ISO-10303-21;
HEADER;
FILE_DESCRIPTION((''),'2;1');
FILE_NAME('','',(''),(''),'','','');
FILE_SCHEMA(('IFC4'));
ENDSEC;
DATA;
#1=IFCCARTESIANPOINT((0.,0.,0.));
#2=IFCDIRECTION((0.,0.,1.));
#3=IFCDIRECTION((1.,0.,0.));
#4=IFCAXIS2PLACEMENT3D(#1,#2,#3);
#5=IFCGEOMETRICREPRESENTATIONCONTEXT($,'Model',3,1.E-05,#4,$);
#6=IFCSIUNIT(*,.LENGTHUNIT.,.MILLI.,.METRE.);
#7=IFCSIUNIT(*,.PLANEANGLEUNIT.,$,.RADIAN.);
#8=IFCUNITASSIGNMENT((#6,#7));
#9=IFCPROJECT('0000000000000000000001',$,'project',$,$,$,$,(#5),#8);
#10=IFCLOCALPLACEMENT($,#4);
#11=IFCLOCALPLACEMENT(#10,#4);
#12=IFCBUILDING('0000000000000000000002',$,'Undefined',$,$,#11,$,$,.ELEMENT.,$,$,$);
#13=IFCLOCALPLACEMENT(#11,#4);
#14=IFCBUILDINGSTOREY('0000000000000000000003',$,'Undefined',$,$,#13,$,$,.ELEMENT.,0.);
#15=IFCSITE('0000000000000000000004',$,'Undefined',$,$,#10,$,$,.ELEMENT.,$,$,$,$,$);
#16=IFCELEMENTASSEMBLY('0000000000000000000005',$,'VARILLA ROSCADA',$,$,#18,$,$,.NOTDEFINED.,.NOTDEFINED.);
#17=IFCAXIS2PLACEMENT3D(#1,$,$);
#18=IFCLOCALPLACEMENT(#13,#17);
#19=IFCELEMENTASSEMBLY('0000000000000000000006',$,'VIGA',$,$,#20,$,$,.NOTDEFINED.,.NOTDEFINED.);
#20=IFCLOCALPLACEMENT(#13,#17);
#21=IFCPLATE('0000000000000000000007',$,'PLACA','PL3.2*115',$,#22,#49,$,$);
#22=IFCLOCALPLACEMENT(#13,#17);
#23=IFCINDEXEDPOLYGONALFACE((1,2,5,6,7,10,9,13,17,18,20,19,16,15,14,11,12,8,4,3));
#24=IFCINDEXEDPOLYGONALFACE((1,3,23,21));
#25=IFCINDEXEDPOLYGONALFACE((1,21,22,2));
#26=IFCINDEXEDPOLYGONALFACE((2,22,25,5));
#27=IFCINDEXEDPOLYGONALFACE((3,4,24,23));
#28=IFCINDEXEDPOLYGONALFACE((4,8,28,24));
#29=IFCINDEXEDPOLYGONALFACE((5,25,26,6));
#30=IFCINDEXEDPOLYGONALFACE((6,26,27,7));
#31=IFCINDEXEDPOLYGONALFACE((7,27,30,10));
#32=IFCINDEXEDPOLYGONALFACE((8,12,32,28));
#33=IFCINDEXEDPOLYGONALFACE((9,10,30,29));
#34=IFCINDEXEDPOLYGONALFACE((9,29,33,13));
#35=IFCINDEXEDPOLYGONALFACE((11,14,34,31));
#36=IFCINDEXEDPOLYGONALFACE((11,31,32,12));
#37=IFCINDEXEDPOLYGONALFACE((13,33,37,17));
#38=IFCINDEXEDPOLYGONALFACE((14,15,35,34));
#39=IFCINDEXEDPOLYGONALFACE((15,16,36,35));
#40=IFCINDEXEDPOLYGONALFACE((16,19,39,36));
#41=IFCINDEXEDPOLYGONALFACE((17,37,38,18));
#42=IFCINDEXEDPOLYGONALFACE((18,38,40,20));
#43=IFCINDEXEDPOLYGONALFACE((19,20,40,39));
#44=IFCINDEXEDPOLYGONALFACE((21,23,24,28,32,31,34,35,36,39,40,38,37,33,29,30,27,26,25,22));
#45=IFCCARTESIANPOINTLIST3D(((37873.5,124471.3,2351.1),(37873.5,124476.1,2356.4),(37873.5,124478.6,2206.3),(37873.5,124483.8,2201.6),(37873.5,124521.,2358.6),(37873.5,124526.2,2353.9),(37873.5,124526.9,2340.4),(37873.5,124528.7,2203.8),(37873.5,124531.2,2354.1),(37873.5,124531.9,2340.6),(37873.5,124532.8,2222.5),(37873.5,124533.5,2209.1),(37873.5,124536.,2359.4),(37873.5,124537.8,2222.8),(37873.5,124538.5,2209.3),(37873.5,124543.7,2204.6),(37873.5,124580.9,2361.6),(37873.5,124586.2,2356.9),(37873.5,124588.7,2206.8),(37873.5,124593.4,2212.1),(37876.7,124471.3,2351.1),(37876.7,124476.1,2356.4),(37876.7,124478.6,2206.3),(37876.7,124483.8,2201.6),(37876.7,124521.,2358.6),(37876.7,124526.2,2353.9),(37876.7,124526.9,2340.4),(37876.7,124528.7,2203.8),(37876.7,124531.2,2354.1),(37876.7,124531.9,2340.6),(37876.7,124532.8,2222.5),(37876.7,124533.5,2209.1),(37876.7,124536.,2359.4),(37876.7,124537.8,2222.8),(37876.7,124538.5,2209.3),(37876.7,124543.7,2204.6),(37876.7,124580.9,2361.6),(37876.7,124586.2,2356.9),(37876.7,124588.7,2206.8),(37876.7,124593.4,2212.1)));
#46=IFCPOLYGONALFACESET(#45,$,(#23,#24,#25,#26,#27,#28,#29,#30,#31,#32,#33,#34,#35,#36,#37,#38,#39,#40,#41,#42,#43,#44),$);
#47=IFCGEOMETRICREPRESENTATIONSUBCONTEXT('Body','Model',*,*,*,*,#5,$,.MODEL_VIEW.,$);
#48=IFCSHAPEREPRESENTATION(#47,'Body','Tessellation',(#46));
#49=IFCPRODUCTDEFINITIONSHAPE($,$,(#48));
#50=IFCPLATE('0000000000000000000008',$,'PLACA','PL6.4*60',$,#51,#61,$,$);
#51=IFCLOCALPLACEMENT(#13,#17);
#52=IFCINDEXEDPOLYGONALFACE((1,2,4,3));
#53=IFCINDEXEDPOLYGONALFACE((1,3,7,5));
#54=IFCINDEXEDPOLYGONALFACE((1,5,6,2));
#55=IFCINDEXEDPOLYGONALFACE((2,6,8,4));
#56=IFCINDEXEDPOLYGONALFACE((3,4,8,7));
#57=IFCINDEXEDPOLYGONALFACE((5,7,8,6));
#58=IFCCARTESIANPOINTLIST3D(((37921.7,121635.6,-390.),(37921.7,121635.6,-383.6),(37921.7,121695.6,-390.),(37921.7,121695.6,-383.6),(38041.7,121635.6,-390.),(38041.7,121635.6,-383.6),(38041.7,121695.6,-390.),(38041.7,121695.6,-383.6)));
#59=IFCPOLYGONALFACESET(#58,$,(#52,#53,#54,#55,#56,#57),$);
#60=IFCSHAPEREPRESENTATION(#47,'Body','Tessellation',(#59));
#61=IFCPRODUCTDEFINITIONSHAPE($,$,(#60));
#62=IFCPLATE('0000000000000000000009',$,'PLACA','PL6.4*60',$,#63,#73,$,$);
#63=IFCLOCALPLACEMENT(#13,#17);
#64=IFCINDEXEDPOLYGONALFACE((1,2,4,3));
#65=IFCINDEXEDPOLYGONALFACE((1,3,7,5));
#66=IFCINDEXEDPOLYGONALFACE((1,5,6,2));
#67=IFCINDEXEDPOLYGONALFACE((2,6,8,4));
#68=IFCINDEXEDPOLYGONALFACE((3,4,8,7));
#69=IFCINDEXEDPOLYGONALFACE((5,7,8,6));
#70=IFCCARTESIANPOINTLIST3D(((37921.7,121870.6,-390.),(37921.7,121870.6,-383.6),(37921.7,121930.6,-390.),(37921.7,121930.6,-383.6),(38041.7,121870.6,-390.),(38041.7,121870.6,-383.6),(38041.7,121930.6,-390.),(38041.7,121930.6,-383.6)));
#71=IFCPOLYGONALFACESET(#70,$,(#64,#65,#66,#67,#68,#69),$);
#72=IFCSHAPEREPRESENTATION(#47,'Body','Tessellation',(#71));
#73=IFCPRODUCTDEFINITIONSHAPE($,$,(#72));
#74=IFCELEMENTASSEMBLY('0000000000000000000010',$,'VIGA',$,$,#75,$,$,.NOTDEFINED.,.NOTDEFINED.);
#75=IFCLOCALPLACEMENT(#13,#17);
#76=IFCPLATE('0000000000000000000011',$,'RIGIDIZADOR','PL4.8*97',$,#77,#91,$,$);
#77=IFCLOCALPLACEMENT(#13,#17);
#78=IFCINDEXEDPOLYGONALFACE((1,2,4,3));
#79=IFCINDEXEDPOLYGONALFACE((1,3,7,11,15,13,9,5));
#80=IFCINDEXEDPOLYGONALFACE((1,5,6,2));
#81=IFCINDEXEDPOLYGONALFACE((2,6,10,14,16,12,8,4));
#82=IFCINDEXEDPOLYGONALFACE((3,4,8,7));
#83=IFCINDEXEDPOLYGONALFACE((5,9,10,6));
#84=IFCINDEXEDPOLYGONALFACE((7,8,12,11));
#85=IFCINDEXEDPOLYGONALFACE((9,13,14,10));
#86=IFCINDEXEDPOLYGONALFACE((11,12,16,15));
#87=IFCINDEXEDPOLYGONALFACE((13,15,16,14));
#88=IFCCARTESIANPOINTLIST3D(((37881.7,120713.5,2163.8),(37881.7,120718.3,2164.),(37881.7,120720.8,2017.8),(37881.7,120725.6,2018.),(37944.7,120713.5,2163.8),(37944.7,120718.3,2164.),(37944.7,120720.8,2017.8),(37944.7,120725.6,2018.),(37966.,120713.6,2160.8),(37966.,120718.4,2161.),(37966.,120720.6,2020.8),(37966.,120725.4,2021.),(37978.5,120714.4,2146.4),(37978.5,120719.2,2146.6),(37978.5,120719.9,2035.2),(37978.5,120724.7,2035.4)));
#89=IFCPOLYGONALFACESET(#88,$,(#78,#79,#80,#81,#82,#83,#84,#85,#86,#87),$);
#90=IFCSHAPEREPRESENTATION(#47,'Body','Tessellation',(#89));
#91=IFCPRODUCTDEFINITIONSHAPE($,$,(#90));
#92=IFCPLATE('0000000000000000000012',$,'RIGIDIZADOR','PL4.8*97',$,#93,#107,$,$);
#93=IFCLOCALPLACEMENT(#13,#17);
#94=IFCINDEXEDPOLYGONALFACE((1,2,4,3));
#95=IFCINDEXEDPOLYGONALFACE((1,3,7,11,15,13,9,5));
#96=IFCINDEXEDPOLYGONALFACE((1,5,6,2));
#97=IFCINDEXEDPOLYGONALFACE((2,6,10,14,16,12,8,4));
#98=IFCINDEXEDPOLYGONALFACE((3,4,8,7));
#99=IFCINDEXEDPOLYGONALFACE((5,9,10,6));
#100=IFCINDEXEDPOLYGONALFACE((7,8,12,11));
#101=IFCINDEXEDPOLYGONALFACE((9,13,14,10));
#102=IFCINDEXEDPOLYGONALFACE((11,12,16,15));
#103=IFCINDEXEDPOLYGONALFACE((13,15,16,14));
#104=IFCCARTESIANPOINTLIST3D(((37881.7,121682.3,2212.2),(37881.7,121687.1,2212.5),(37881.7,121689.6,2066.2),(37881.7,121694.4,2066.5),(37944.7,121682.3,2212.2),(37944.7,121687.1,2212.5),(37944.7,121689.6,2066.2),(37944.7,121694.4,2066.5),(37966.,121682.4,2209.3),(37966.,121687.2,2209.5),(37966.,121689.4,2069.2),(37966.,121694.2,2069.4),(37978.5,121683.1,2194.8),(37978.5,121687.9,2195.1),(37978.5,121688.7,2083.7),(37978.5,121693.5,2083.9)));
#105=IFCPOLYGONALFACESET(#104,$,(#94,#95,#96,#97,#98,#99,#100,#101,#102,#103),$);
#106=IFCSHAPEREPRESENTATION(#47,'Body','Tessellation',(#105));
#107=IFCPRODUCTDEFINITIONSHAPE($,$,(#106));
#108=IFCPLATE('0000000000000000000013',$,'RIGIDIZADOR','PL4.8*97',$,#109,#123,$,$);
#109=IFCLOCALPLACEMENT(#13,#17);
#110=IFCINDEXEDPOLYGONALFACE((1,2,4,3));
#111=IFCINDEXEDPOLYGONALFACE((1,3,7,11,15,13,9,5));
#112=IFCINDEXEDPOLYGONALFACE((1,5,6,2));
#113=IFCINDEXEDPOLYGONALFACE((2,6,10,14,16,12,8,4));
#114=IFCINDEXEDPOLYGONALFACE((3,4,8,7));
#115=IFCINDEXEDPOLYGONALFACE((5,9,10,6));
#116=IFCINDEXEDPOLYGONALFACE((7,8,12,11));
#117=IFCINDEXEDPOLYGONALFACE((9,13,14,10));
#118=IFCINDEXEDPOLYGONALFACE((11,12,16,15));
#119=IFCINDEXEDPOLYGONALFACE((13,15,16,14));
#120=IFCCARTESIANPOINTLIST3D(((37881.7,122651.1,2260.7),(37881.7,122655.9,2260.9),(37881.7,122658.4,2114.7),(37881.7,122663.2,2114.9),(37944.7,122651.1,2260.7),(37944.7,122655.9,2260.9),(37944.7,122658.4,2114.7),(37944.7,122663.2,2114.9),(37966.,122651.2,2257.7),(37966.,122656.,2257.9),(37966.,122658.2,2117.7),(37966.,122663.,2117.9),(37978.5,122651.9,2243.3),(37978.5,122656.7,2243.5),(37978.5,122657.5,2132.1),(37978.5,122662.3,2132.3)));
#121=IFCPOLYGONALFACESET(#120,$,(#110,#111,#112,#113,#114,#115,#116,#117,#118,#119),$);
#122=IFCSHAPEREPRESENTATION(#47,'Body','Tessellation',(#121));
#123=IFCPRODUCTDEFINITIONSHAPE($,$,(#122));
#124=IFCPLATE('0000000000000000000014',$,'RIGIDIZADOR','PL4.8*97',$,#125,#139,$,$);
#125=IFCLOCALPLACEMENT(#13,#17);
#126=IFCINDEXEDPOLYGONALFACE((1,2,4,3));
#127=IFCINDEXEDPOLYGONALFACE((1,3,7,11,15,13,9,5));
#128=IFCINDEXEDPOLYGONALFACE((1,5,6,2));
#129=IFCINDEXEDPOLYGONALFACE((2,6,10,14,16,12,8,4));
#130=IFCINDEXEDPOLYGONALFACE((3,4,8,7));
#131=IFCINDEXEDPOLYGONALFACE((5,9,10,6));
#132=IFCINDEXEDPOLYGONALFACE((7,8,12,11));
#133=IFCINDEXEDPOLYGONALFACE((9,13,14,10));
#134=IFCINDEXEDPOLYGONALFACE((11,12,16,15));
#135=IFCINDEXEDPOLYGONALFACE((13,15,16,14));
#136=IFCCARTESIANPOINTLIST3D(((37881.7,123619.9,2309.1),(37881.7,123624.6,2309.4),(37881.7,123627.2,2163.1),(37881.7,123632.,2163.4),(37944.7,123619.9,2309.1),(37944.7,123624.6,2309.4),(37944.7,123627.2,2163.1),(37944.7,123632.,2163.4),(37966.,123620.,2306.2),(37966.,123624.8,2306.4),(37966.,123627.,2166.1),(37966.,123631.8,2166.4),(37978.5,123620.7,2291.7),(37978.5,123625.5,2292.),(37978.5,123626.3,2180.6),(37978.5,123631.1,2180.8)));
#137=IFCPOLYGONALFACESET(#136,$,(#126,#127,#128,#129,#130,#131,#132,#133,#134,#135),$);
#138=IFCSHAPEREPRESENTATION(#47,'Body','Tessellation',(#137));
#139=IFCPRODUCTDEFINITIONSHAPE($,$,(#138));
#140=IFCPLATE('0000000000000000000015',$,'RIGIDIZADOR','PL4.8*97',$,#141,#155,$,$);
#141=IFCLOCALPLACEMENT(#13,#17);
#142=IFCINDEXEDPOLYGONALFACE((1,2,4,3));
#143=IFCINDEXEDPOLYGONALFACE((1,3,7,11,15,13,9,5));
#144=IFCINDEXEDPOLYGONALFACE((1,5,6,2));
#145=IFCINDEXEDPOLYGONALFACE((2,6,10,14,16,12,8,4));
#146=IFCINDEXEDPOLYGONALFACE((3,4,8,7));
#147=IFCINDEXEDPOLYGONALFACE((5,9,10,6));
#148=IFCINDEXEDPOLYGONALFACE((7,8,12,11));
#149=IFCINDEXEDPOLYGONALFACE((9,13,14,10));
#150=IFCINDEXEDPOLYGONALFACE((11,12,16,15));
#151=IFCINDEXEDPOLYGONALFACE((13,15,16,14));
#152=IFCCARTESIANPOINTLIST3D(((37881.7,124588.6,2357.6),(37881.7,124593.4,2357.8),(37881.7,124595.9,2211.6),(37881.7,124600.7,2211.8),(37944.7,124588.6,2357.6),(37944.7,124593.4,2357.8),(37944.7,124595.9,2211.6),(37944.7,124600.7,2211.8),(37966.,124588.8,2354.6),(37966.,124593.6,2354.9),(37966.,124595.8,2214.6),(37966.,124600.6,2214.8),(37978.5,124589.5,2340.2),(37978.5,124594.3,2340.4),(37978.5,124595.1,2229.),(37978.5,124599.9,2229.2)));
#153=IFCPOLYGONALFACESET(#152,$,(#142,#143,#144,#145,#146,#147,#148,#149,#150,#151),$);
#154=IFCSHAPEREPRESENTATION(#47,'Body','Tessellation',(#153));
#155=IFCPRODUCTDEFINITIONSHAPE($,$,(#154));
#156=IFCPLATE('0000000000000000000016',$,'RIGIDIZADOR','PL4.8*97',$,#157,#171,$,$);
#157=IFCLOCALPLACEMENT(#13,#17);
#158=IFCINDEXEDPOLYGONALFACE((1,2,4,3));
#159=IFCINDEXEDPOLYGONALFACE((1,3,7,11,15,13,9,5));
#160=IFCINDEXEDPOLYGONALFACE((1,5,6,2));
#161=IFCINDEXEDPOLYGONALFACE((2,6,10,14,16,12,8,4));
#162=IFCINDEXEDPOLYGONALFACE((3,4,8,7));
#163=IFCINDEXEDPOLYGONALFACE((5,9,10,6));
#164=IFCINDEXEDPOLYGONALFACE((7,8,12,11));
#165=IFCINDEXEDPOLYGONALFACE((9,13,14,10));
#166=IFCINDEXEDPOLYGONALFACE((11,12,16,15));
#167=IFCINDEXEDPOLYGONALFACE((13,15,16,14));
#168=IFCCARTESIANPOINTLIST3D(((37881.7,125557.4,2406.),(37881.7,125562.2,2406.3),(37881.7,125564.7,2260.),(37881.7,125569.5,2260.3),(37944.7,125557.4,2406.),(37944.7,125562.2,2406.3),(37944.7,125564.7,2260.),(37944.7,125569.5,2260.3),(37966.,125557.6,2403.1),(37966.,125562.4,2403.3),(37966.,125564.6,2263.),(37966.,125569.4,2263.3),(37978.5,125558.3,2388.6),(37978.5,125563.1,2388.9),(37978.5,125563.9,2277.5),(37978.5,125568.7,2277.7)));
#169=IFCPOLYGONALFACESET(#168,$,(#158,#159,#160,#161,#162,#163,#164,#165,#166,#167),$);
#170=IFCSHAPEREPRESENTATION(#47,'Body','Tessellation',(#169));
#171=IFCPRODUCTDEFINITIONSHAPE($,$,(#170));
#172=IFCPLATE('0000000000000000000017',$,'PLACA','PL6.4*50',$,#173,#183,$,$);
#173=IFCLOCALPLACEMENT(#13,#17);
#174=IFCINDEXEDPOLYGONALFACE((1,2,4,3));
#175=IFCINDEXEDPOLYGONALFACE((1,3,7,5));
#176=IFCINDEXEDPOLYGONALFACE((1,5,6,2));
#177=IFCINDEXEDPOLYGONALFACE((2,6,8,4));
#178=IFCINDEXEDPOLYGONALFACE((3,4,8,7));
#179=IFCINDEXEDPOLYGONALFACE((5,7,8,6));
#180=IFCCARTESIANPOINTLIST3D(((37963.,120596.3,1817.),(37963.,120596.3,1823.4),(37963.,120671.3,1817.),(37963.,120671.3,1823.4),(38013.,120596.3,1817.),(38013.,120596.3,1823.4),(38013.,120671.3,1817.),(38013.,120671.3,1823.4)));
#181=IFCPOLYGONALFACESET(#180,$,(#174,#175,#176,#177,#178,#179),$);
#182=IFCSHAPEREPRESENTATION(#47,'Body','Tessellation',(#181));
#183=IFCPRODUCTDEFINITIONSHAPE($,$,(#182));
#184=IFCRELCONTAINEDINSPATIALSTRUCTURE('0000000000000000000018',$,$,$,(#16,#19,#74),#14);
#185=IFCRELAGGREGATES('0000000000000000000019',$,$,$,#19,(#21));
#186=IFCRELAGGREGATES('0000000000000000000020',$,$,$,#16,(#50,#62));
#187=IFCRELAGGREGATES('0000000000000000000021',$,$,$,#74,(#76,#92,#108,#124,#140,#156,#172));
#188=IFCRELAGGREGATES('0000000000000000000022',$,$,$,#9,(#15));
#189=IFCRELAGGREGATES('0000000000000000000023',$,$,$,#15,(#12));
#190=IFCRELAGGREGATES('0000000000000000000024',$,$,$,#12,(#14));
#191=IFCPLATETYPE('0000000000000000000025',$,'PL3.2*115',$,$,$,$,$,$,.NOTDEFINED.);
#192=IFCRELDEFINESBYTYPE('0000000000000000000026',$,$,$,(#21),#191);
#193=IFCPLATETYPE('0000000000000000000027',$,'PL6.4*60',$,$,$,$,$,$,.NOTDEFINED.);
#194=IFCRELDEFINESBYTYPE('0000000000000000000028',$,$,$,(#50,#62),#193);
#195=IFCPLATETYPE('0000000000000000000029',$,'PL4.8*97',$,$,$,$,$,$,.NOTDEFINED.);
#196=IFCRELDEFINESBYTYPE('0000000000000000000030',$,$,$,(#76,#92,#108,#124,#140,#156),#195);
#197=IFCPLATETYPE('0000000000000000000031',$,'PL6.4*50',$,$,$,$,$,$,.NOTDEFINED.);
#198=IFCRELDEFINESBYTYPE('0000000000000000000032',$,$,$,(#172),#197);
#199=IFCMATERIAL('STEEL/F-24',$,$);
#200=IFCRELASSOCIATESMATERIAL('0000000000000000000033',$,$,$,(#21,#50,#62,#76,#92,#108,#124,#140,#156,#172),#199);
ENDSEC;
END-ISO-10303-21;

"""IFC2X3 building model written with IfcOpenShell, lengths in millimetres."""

from ifc_helpers import new_model, si_unit, frame, origin_with_axes, place, context, subcontext, project, spatial, polyline, outline, extrude, material, type_object, element, aggregate, save


model = new_model("IFC2X3")

# Units and contexts
model_context = context("Model", 3, precision=1e-05, world=origin_with_axes())
body_context = subcontext(model_context, "Body", "Model", "MODEL_VIEW")
ifc_project = project(units=[si_unit("LENGTHUNIT", "METRE", prefix="MILLI"), si_unit("PLANEANGLEUNIT", "RADIAN")], contexts=[model_context])

# Site, building, storey
site_placement = place(None, origin_with_axes())
site = spatial("IfcSite", under=ifc_project, at=site_placement, Name="Undefined", CompositionType="ELEMENT")
building_placement = place(site_placement, origin_with_axes())
building = spatial("IfcBuilding", under=site, at=building_placement, Name="Undefined", CompositionType="ELEMENT")
storey_placement = place(building_placement, origin_with_axes())
storey = spatial("IfcBuildingStorey", under=building, at=storey_placement, Name="Undefined", CompositionType="ELEMENT", Elevation=0.0)

# Element assembly
assembly_1_placement = place(storey_placement, origin_with_axes())
assembly_1 = element("IfcElementAssembly", 1, at=assembly_1_placement, inside=storey, Name="VARILLA ROSCADA", AssemblyPlace="NOTDEFINED", PredefinedType="NOTDEFINED")

# Shared definitions
ifc_material_1 = material(Name="STEEL/F-24")

# Shared definitions
plate_type_1 = type_object("IfcPlateType", Name="PL3.2*115", PredefinedType="NOTDEFINED")

# Element assembly, plate
assembly_2_placement = place(storey_placement, origin_with_axes())
assembly_2 = element("IfcElementAssembly", 2, at=assembly_2_placement, inside=storey, Name="VIGA", AssemblyPlace="NOTDEFINED", PredefinedType="NOTDEFINED")
plate_1_placement = place(assembly_2_placement, frame((37875.1, 124471.1, 2356.1), z_axis=(-1.0, 0.0, 0.0), x_axis=(0.0, 0.998752, 0.04995)))
plate_1 = element("IfcPlate", 3, at=plate_1_placement, type_object=plate_type_1, material=ifc_material_1, Name="PLACA", Description="PL3.2*115", context=body_context, shape_type="SweptSolid", body=[
    extrude(outline(polyline([(0.0, 5.0), (5.0, 0.0), (50.0, 0.0), (55.0, 5.0), (55.0, 18.5), (60.0, 18.5), (60.0, 5.0), (65.0, 0.0), (110.0, 0.0), (115.0, 5.0), (115.0, 150.0), (110.0, 155.0), (65.0, 155.0), (60.0, 150.0), (60.0, 136.5), (55.0, 136.5), (55.0, 150.0), (50.0, 155.0), (5.0, 155.0), (0.0, 150.0), (0.0, 5.0)])), frame((0.0, 0.0, -1.6), z_axis=(0.0, 0.0, 1.0), x_axis=(1.0, 0.0, 0.0)), (0.0, 0.0, 1.0), 3.2),
])

# Plates
plate_type_2 = type_object("IfcPlateType", Name="PL6.4*60", PredefinedType="NOTDEFINED")
plate_2_placement = place(assembly_1_placement, frame((37921.7, 121635.6, -386.8), z_axis=(0.0, 0.0, 1.0), x_axis=(1.0, 0.0, 0.0)))
plate_2 = element("IfcPlate", 4, at=plate_2_placement, type_object=plate_type_2, material=ifc_material_1, Name="PLACA", Description="PL6.4*60", context=body_context, shape_type="SweptSolid", body=[
    extrude(outline(polyline([(0.0, 0.0), (120.0, 0.0), (120.0, 60.0), (0.0, 60.0), (0.0, 0.0)])), frame((0.0, 0.0, -3.2), z_axis=(0.0, 0.0, 1.0), x_axis=(1.0, 0.0, 0.0)), (0.0, 0.0, 1.0), 6.4),
])
plate_3_placement = place(assembly_1_placement, frame((37921.7, 121870.6, -386.8), z_axis=(0.0, 0.0, 1.0), x_axis=(1.0, 0.0, 0.0)))
plate_3 = element("IfcPlate", 5, at=plate_3_placement, type_object=plate_type_2, material=ifc_material_1, Name="PLACA", Description="PL6.4*60", context=body_context, shape_type="SweptSolid", body=[
    extrude(outline(polyline([(0.0, 0.0), (120.0, 0.0), (120.0, 60.0), (0.0, 60.0), (0.0, 0.0)])), frame((0.0, 0.0, -3.2), z_axis=(0.0, 0.0, 1.0), x_axis=(1.0, 0.0, 0.0)), (0.0, 0.0, 1.0), 6.4),
])

# Element assembly, plates
assembly_3_placement = place(storey_placement, origin_with_axes())
assembly_3 = element("IfcElementAssembly", 6, at=assembly_3_placement, inside=storey, Name="VIGA", AssemblyPlace="NOTDEFINED", PredefinedType="NOTDEFINED")
plate_type_3 = type_object("IfcPlateType", Name="PL4.8*97", PredefinedType="NOTDEFINED")
plate_4_placement = place(assembly_3_placement, frame((37881.7, 120715.9, 2163.9), z_axis=(0.0, 0.998752, 0.04995), x_axis=(1.0, 0.0, 0.0)))
plate_4 = element("IfcPlate", 7, at=plate_4_placement, type_object=plate_type_3, material=ifc_material_1, Name="RIGIDIZADOR", Description="PL4.8*97", context=body_context, shape_type="SweptSolid", body=[
    extrude(outline(polyline([(0.0, 0.0), (63.0, 0.0), (84.3, 3.0), (96.8, 17.4), (96.8, 128.7), (84.3, 143.2), (63.0, 146.2), (0.0, 146.2), (0.0, 0.0)])), frame((0.0, 0.0, -2.4), z_axis=(0.0, 0.0, 1.0), x_axis=(1.0, 0.0, 0.0)), (0.0, 0.0, 1.0), 4.8),
])
plate_5_placement = place(assembly_3_placement, frame((37881.7, 121684.7, 2212.4), z_axis=(0.0, 0.998752, 0.04995), x_axis=(1.0, 0.0, 0.0)))
plate_5 = element("IfcPlate", 8, at=plate_5_placement, type_object=plate_type_3, material=ifc_material_1, Name="RIGIDIZADOR", Description="PL4.8*97", context=body_context, shape_type="SweptSolid", body=[
    extrude(outline(polyline([(0.0, 0.0), (63.0, 0.0), (84.3, 3.0), (96.8, 17.4), (96.8, 128.7), (84.3, 143.2), (63.0, 146.2), (0.0, 146.2), (0.0, 0.0)])), frame((0.0, 0.0, -2.4), z_axis=(0.0, 0.0, 1.0), x_axis=(1.0, 0.0, 0.0)), (0.0, 0.0, 1.0), 4.8),
])
plate_6_placement = place(assembly_3_placement, frame((37881.7, 122653.5, 2260.8), z_axis=(0.0, 0.998752, 0.04995), x_axis=(1.0, 0.0, 0.0)))
plate_6 = element("IfcPlate", 9, at=plate_6_placement, type_object=plate_type_3, material=ifc_material_1, Name="RIGIDIZADOR", Description="PL4.8*97", context=body_context, shape_type="SweptSolid", body=[
    extrude(outline(polyline([(0.0, 0.0), (63.0, 0.0), (84.3, 3.0), (96.8, 17.4), (96.8, 128.7), (84.3, 143.2), (63.0, 146.2), (0.0, 146.2), (0.0, 0.0)])), frame((0.0, 0.0, -2.4), z_axis=(0.0, 0.0, 1.0), x_axis=(1.0, 0.0, 0.0)), (0.0, 0.0, 1.0), 4.8),
])
plate_7_placement = place(assembly_3_placement, frame((37881.7, 123622.3, 2309.3), z_axis=(0.0, 0.998752, 0.04995), x_axis=(1.0, 0.0, 0.0)))
plate_7 = element("IfcPlate", 10, at=plate_7_placement, type_object=plate_type_3, material=ifc_material_1, Name="RIGIDIZADOR", Description="PL4.8*97", context=body_context, shape_type="SweptSolid", body=[
    extrude(outline(polyline([(0.0, 0.0), (63.0, 0.0), (84.3, 3.0), (96.8, 17.4), (96.8, 128.7), (84.3, 143.2), (63.0, 146.2), (0.0, 146.2), (0.0, 0.0)])), frame((0.0, 0.0, -2.4), z_axis=(0.0, 0.0, 1.0), x_axis=(1.0, 0.0, 0.0)), (0.0, 0.0, 1.0), 4.8),
])
plate_8_placement = place(assembly_3_placement, frame((37881.7, 124591.0, 2357.7), z_axis=(0.0, 0.998752, 0.04995), x_axis=(1.0, 0.0, 0.0)))
plate_8 = element("IfcPlate", 11, at=plate_8_placement, type_object=plate_type_3, material=ifc_material_1, Name="RIGIDIZADOR", Description="PL4.8*97", context=body_context, shape_type="SweptSolid", body=[
    extrude(outline(polyline([(0.0, 0.0), (63.0, 0.0), (84.3, 3.0), (96.8, 17.4), (96.8, 128.7), (84.3, 143.2), (63.0, 146.2), (0.0, 146.2), (0.0, 0.0)])), frame((0.0, 0.0, -2.4), z_axis=(0.0, 0.0, 1.0), x_axis=(1.0, 0.0, 0.0)), (0.0, 0.0, 1.0), 4.8),
])
plate_9_placement = place(assembly_3_placement, frame((37881.7, 125559.8, 2406.2), z_axis=(0.0, 0.998752, 0.04995), x_axis=(1.0, 0.0, 0.0)))
plate_9 = element("IfcPlate", 12, at=plate_9_placement, type_object=plate_type_3, material=ifc_material_1, Name="RIGIDIZADOR", Description="PL4.8*97", context=body_context, shape_type="SweptSolid", body=[
    extrude(outline(polyline([(0.0, 0.0), (63.0, 0.0), (84.3, 3.0), (96.8, 17.4), (96.8, 128.7), (84.3, 143.2), (63.0, 146.2), (0.0, 146.2), (0.0, 0.0)])), frame((0.0, 0.0, -2.4), z_axis=(0.0, 0.0, 1.0), x_axis=(1.0, 0.0, 0.0)), (0.0, 0.0, 1.0), 4.8),
])
plate_type_4 = type_object("IfcPlateType", Name="PL6.4*50", PredefinedType="NOTDEFINED")
plate_10_placement = place(assembly_3_placement, frame((37963.0, 120671.3, 1820.2), z_axis=(0.0, 0.0, 1.0), x_axis=(0.0, -1.0, 0.0)))
plate_10 = element("IfcPlate", 13, at=plate_10_placement, type_object=plate_type_4, material=ifc_material_1, Name="PLACA", Description="PL6.4*50", context=body_context, shape_type="SweptSolid", body=[
    extrude(outline(polyline([(0.0, 0.0), (75.0, 0.0), (75.0, 50.0), (0.0, 50.0), (0.0, 0.0)])), frame((0.0, 0.0, -3.2), z_axis=(0.0, 0.0, 1.0), x_axis=(1.0, 0.0, 0.0)), (0.0, 0.0, 1.0), 6.4),
])

aggregate(assembly_2, [plate_1])
aggregate(assembly_1, [plate_2, plate_3])
aggregate(assembly_3, [plate_4, plate_5, plate_6, plate_7, plate_8, plate_9, plate_10])

save(model, "model.ifc")
